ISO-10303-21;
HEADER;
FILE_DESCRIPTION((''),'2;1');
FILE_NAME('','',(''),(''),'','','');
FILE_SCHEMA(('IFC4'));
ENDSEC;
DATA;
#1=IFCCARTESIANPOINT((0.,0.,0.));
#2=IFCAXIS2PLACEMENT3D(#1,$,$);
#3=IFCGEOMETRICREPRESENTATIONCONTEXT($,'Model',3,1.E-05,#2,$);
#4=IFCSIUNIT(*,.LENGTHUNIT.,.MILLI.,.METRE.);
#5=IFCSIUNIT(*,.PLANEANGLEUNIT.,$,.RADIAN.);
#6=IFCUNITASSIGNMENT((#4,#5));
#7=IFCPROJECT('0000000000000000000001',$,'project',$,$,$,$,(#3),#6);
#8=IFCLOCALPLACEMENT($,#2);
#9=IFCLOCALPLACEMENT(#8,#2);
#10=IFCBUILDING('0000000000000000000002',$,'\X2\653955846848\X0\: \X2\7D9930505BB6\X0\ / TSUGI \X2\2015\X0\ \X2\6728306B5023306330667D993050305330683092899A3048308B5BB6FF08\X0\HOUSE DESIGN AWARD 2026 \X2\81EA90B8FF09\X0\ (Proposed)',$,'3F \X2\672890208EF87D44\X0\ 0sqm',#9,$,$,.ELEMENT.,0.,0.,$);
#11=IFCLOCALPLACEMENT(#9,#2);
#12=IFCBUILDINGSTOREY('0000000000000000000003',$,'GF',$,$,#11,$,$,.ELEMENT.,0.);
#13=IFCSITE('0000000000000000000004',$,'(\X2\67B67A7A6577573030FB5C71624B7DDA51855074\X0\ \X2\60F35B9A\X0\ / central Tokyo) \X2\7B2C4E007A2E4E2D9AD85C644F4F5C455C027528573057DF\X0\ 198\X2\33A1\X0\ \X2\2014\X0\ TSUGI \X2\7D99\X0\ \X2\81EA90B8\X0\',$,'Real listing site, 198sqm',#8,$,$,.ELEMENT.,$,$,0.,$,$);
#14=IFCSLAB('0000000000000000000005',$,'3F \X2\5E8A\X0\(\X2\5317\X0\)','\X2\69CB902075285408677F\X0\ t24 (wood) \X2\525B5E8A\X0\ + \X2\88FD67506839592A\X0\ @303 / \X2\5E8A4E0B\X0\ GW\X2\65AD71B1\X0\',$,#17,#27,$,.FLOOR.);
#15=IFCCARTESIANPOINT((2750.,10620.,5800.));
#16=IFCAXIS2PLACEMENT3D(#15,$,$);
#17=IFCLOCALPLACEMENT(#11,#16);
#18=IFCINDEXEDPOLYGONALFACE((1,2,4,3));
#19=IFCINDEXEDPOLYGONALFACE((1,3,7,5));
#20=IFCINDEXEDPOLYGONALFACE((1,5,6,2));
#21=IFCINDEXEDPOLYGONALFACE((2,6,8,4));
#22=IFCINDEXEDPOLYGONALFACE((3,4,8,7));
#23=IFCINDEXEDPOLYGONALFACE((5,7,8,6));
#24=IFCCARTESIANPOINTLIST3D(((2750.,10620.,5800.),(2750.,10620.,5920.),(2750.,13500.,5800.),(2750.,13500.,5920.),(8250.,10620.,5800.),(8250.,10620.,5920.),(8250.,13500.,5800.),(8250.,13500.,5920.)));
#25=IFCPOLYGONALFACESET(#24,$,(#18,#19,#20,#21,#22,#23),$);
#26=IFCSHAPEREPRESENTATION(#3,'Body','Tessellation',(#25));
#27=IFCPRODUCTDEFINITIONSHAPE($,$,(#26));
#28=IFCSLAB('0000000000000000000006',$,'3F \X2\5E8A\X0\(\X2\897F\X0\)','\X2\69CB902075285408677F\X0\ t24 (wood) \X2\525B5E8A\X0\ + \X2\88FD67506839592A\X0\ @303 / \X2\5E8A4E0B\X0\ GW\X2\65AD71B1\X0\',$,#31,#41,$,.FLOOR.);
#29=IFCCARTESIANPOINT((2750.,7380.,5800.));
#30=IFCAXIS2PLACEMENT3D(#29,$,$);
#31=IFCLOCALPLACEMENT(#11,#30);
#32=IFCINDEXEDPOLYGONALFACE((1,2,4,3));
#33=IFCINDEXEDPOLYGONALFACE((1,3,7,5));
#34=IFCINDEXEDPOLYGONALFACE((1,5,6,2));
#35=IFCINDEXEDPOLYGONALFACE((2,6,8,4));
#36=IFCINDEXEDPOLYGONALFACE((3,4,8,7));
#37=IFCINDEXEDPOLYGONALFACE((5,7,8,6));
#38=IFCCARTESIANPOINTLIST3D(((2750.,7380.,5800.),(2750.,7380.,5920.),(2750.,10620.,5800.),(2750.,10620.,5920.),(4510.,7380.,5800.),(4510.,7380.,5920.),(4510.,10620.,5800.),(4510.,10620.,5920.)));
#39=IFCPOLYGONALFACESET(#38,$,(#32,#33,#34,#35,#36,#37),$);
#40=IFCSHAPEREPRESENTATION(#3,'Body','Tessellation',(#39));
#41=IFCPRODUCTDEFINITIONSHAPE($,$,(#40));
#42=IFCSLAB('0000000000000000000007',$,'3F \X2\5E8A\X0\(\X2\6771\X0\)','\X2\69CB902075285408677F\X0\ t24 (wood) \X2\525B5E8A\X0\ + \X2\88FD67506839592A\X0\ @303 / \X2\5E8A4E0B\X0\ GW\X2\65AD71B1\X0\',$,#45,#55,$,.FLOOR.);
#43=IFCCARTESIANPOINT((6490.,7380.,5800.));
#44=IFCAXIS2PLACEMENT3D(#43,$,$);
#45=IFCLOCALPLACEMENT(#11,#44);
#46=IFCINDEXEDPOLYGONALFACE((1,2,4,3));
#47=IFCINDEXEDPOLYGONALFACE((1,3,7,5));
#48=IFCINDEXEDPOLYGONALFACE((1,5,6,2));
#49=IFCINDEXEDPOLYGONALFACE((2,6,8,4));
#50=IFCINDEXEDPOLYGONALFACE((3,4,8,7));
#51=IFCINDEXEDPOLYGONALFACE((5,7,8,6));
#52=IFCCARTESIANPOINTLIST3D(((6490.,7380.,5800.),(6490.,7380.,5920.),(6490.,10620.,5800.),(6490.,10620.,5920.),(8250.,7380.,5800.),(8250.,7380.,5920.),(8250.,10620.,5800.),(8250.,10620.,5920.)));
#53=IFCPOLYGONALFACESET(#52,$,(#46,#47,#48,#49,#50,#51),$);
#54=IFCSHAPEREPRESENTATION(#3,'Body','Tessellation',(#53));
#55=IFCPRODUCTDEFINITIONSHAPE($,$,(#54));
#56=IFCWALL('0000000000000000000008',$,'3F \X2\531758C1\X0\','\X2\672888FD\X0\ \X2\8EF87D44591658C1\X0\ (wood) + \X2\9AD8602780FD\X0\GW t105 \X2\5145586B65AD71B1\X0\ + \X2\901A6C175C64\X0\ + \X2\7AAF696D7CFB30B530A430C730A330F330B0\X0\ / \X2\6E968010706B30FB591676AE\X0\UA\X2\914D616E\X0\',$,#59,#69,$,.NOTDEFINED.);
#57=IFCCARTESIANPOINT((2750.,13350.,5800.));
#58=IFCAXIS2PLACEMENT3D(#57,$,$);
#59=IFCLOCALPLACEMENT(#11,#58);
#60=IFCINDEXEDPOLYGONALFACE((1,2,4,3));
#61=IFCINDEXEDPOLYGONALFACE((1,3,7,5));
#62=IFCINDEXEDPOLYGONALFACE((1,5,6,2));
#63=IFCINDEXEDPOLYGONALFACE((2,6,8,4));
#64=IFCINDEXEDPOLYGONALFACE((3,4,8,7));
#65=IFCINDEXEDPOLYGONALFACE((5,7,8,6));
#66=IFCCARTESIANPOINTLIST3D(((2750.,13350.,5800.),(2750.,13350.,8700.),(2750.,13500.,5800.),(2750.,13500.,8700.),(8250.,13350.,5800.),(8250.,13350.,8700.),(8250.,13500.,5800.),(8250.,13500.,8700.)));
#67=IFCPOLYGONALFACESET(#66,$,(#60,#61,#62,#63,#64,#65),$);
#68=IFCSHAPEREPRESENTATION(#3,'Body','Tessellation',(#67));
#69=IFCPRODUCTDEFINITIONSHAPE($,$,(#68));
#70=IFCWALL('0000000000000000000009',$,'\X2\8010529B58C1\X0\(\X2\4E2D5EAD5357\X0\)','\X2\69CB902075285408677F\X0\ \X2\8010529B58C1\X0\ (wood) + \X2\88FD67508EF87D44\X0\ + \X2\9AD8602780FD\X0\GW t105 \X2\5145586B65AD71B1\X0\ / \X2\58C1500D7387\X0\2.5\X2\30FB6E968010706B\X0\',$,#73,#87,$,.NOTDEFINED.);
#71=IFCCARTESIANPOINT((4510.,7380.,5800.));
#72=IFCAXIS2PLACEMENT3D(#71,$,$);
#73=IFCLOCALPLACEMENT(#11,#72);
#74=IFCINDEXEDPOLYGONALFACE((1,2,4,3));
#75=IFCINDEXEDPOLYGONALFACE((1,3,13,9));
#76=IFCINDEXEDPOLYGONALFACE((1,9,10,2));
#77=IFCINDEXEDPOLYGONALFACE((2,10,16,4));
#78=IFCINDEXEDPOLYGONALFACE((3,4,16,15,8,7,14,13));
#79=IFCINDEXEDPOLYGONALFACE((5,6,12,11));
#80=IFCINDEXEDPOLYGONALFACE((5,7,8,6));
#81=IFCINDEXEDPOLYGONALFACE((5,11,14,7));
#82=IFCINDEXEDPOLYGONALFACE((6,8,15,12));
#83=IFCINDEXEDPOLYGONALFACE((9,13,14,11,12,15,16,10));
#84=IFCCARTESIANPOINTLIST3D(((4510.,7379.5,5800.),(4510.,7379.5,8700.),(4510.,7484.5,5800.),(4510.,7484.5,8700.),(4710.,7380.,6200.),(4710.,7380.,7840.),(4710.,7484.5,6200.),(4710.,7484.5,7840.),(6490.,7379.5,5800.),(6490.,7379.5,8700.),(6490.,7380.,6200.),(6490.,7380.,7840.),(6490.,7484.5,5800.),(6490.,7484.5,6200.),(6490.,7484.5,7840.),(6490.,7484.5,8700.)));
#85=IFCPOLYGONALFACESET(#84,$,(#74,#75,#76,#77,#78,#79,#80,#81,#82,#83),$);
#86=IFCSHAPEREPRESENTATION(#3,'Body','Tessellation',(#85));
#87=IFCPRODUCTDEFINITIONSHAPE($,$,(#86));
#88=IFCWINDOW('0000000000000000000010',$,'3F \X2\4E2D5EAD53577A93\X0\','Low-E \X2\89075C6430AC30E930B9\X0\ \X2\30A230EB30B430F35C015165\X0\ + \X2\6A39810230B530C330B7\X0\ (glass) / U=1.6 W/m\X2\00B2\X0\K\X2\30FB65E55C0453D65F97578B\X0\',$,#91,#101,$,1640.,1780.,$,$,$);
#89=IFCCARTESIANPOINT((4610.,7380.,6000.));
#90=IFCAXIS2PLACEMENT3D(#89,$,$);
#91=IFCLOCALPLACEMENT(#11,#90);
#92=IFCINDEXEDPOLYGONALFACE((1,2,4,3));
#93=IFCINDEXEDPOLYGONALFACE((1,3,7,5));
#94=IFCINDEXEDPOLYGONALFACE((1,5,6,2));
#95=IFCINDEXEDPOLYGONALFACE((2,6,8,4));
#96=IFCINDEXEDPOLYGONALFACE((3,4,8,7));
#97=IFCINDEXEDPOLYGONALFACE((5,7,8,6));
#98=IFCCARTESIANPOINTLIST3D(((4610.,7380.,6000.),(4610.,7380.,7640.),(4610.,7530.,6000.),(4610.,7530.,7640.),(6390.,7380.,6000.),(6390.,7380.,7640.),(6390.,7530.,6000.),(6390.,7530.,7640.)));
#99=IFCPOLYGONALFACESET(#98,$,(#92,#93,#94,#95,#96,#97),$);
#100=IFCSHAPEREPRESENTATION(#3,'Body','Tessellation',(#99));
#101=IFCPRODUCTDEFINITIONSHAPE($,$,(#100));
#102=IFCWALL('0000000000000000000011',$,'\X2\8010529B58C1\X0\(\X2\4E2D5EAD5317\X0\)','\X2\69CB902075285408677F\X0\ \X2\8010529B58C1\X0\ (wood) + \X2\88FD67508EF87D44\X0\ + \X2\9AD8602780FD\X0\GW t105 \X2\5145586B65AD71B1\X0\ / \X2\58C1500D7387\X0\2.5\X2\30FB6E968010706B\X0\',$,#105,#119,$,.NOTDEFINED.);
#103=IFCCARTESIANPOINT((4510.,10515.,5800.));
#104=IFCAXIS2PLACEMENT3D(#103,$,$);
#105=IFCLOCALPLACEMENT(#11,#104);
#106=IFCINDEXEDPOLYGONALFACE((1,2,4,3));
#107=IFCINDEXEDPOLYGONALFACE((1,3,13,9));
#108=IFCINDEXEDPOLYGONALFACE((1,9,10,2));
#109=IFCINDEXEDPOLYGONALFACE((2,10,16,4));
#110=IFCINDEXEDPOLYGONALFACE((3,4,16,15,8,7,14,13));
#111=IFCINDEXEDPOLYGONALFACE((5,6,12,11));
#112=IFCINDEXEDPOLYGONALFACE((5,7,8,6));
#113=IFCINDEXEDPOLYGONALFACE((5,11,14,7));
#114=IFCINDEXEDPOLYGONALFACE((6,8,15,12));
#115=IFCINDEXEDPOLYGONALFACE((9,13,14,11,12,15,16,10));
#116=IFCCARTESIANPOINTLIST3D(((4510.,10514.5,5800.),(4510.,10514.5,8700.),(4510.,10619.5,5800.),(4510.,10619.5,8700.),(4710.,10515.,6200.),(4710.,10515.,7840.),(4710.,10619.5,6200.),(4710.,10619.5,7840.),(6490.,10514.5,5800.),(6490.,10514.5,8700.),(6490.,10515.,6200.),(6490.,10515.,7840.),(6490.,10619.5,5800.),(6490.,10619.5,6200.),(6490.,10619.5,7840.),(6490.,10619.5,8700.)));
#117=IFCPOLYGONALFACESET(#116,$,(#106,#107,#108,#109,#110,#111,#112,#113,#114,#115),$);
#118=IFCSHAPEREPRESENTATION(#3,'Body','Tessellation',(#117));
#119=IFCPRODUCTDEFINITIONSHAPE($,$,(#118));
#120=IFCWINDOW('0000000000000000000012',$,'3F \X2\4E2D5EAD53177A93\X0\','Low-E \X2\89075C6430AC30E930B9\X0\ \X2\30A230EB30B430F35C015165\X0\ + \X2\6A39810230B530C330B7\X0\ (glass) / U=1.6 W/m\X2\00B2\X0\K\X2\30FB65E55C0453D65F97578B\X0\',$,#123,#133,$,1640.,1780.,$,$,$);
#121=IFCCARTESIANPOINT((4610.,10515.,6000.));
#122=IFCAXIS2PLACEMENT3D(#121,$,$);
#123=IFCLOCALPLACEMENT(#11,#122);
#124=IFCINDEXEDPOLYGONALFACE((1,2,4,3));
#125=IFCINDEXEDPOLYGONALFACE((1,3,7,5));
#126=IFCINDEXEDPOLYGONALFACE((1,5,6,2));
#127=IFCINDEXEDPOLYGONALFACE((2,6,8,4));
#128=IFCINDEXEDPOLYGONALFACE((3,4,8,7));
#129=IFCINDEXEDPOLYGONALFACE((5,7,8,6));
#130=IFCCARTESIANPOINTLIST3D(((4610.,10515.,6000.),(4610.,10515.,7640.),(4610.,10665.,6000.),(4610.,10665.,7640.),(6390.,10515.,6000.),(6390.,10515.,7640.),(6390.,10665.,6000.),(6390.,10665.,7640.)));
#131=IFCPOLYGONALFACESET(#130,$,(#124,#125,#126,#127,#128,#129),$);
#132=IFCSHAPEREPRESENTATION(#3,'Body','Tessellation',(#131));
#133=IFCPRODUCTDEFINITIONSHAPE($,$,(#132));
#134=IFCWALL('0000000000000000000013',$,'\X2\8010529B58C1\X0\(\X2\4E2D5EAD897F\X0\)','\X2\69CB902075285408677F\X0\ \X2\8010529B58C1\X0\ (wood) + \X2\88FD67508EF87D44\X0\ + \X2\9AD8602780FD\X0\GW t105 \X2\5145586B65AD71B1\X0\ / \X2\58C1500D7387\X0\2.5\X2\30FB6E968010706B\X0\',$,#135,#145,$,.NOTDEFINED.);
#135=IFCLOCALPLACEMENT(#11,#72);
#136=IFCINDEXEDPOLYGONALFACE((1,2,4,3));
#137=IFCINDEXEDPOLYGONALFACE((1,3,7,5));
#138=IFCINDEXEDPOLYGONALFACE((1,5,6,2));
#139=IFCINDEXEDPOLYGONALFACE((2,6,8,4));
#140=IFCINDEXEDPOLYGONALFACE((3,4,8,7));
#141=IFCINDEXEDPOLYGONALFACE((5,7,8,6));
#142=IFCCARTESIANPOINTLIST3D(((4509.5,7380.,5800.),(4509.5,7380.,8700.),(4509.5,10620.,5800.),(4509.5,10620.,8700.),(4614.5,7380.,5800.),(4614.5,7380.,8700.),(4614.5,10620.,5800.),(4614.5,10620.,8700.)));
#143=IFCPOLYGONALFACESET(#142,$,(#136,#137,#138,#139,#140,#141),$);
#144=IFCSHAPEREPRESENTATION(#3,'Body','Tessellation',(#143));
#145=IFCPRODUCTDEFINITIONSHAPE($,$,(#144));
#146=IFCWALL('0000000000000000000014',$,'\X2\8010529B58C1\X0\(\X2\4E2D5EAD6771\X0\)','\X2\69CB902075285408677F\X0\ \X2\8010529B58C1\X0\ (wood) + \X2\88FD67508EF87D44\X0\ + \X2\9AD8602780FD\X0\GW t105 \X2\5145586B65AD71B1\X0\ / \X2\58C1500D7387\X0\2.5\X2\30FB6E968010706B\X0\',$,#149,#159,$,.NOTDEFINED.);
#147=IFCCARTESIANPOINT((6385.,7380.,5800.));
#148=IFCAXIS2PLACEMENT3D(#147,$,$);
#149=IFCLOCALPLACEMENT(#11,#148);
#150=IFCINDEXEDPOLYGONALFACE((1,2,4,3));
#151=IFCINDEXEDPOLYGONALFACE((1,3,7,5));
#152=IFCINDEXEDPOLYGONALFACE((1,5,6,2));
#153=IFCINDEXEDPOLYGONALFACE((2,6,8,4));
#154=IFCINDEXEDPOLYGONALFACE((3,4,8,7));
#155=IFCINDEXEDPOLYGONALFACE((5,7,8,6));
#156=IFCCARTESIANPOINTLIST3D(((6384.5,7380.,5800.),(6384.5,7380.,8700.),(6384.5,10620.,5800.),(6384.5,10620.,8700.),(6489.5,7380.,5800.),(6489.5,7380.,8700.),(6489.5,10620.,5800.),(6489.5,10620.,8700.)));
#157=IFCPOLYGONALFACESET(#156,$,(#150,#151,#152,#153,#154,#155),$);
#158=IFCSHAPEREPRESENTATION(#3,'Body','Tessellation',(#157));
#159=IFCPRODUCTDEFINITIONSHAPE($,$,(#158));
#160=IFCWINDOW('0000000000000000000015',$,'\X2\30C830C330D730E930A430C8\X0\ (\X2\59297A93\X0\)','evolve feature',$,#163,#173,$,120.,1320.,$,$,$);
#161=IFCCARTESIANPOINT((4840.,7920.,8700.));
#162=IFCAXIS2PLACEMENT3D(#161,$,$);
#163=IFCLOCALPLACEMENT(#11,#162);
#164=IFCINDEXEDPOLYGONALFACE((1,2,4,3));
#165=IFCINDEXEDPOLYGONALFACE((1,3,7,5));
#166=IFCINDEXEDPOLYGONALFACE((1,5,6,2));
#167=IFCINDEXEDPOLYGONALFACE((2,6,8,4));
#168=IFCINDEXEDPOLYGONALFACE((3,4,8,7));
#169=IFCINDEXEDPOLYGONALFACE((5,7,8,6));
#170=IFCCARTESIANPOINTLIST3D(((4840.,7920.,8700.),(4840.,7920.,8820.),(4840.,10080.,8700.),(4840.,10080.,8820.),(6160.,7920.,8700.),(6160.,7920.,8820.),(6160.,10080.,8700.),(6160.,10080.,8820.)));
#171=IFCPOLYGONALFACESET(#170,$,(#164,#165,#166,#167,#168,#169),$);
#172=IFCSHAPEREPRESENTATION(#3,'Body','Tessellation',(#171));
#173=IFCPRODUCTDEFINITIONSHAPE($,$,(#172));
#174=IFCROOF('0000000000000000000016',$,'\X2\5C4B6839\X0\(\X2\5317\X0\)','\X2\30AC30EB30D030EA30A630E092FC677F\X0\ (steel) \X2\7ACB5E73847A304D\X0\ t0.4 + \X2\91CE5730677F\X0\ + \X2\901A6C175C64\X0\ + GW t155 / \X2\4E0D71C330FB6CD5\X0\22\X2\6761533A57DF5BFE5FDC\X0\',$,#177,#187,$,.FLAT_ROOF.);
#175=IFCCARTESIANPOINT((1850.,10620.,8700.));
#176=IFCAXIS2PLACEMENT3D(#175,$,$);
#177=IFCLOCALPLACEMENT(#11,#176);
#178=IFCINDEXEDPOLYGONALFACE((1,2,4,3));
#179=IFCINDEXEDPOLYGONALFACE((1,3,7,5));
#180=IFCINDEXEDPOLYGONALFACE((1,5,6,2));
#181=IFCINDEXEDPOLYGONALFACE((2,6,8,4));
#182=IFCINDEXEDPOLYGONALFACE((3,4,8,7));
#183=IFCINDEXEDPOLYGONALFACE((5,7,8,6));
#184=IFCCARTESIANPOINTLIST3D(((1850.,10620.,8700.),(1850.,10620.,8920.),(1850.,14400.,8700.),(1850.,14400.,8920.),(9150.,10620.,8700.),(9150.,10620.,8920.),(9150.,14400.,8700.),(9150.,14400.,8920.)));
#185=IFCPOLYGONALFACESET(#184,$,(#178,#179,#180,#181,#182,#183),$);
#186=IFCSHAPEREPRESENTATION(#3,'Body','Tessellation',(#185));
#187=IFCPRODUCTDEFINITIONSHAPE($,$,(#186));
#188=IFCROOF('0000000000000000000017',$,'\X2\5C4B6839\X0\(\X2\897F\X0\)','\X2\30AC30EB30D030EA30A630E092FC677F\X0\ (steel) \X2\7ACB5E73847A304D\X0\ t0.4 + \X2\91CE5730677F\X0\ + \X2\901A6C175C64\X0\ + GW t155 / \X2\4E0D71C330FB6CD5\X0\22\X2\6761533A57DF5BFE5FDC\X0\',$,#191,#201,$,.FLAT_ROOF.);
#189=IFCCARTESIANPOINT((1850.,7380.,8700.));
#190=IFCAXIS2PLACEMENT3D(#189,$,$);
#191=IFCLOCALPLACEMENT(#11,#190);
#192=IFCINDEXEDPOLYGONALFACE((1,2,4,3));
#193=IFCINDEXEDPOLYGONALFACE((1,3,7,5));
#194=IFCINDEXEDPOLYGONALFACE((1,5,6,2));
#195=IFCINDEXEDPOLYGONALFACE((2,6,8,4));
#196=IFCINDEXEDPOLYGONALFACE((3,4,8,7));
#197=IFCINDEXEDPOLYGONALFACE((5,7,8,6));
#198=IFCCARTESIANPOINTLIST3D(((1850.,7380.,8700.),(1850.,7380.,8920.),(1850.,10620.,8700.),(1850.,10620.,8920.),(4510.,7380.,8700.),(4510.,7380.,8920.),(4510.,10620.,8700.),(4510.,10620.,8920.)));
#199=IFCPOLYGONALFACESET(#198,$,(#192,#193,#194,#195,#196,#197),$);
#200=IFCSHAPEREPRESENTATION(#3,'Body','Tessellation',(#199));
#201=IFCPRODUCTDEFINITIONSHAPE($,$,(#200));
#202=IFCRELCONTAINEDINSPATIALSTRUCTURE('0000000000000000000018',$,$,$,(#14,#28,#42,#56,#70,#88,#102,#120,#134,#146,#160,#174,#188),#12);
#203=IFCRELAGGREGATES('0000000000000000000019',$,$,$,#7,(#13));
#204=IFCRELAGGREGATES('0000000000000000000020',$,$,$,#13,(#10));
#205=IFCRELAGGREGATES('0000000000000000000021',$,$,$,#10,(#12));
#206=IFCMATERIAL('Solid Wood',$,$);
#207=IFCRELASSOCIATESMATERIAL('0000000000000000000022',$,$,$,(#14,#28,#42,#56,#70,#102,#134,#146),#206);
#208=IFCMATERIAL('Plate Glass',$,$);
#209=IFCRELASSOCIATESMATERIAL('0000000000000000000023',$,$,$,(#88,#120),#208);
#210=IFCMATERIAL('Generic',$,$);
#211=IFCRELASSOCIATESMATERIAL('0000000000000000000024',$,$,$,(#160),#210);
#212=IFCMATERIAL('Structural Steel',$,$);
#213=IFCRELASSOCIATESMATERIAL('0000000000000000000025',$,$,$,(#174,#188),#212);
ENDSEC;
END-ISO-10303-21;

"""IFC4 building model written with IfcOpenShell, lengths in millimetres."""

from ifc_helpers import new_model, si_unit, frame, frame_2d, origin, place, context, project, spatial, rectangle, extrude, material, element, fill, save


model = new_model("IFC4")

# Units and contexts
model_context = context("Model", 3, precision=1e-05, world=origin())
ifc_project = project(units=[si_unit("LENGTHUNIT", "METRE", prefix="MILLI"), si_unit("PLANEANGLEUNIT", "RADIAN")], contexts=[model_context])

# Site, building, storey
site_placement = place(None, origin())
site = spatial("IfcSite", under=ifc_project, at=site_placement, Name="(架空敷地・山手線内側 想定 / central Tokyo) 第一種中高層住居専用地域 198㎡ — TSUGI 継 自邸", ObjectType="Real listing site, 198sqm", CompositionType="ELEMENT", RefElevation=0.0)
building_placement = place(site_placement, origin())
building = spatial("IfcBuilding", under=site, at=building_placement, Name="改善案: 継ぐ家 / TSUGI ― 木に倣って継ぐことを覚える家（HOUSE DESIGN AWARD 2026 自邸） (Proposed)", ObjectType="3F 木造軸組 0sqm", CompositionType="ELEMENT", ElevationOfRefHeight=0.0, ElevationOfTerrain=0.0)
storey_placement = place(building_placement, origin())
storey = spatial("IfcBuildingStorey", under=building, at=storey_placement, Name="GF", CompositionType="ELEMENT", Elevation=0.0)

# Slabs
ifc_material_1 = material(Name="Solid Wood")
slab_1_placement = place(storey_placement, frame((2750.0, 10620.0, 5800.0)))
element("IfcSlab", 1, at=slab_1_placement, inside=storey, material=ifc_material_1, Name="3F 床(北)", Description="構造用合板 t24 (wood) 剛床 + 製材根太 @303 / 床下 GW断熱", PredefinedType="FLOOR", context=model_context, shape_type="SweptSolid", body=[
    extrude(rectangle(XDim=5500.0, YDim=2880.0, at=frame_2d((2750.0, 1440.0))), frame((2750.0, 10620.0, 5800.0)), (0.0, 0.0, 1.0), 120.0),
])
slab_2_placement = place(storey_placement, frame((2750.0, 7380.0, 5800.0)))
element("IfcSlab", 2, at=slab_2_placement, inside=storey, material=ifc_material_1, Name="3F 床(西)", Description="構造用合板 t24 (wood) 剛床 + 製材根太 @303 / 床下 GW断熱", PredefinedType="FLOOR", context=model_context, shape_type="SweptSolid", body=[
    extrude(rectangle(XDim=1760.0, YDim=3240.0, at=frame_2d((880.0, 1620.0))), frame((2750.0, 7380.0, 5800.0)), (0.0, 0.0, 1.0), 120.0),
])
slab_3_placement = place(storey_placement, frame((6490.0, 7380.0, 5800.0)))
element("IfcSlab", 3, at=slab_3_placement, inside=storey, material=ifc_material_1, Name="3F 床(東)", Description="構造用合板 t24 (wood) 剛床 + 製材根太 @303 / 床下 GW断熱", PredefinedType="FLOOR", context=model_context, shape_type="SweptSolid", body=[
    extrude(rectangle(XDim=1760.0, YDim=3240.0, at=frame_2d((880.0, 1620.0))), frame((6490.0, 7380.0, 5800.0)), (0.0, 0.0, 1.0), 120.0),
])

# Wall
wall_1_placement = place(storey_placement, frame((2750.0, 13350.0, 5800.0)))
element("IfcWall", 4, at=wall_1_placement, inside=storey, material=ifc_material_1, Name="3F 北壁", Description="木製 軸組外壁 (wood) + 高性能GW t105 充填断熱 + 通気層 + 窯業系サイディング / 準耐火・外皮UA配慮", PredefinedType="NOTDEFINED", context=model_context, shape_type="SweptSolid", body=[
    extrude(rectangle(XDim=5500.0, YDim=150.0, at=frame_2d((2750.0, 75.0))), frame((2750.0, 13350.0, 5800.0)), (0.0, 0.0, 1.0), 2900.0),
])

# Walls, openings, windows
wall_2_placement = place(storey_placement, frame((4510.0, 7380.0, 5800.0)))
wall_2 = element("IfcWall", 5, at=wall_2_placement, inside=storey, material=ifc_material_1, Name="耐力壁(中庭南)", Description="構造用合板 耐力壁 (wood) + 製材軸組 + 高性能GW t105 充填断熱 / 壁倍率2.5・準耐火", PredefinedType="NOTDEFINED", context=model_context, shape_type="SweptSolid", body=[
    extrude(rectangle(XDim=1980.0, YDim=105.0, at=frame_2d((990.0, 52.0))), frame((4510.0, 7380.0, 5800.0)), (0.0, 0.0, 1.0), 2900.0),
])
opening_1_placement = place(storey_placement, frame((4610.0, 7380.0, 6000.0)))
opening_1 = element("IfcOpeningElement", 6, at=opening_1_placement, cuts=wall_2, PredefinedType="NOTDEFINED", context=model_context, shape_type="SweptSolid", body=[
    extrude(rectangle(XDim=1780.0, YDim=150.0, at=frame_2d((890.0, 75.0))), frame((4610.0, 7380.0, 6000.0)), (0.0, 0.0, 1.0), 1640.0),
])
ifc_material_2 = material(Name="Plate Glass")
window_1_placement = place(storey_placement, frame((4610.0, 7380.0, 6000.0)))
window_1 = element("IfcWindow", 7, at=window_1_placement, inside=storey, material=ifc_material_2, Name="3F 中庭南窓", Description="Low-E 複層ガラス アルゴン封入 + 樹脂サッシ (glass) / U=1.6 W/m²K・日射取得型", OverallHeight=1640.0, OverallWidth=1780.0, context=model_context, shape_type="SweptSolid", body=[
    extrude(rectangle(XDim=1780.0, YDim=150.0, at=frame_2d((890.0, 75.0))), frame((4610.0, 7380.0, 6000.0)), (0.0, 0.0, 1.0), 1640.0),
])
fill(opening_1, window_1)
wall_3_placement = place(storey_placement, frame((4510.0, 10515.0, 5800.0)))
wall_3 = element("IfcWall", 8, at=wall_3_placement, inside=storey, material=ifc_material_1, Name="耐力壁(中庭北)", Description="構造用合板 耐力壁 (wood) + 製材軸組 + 高性能GW t105 充填断熱 / 壁倍率2.5・準耐火", PredefinedType="NOTDEFINED", context=model_context, shape_type="SweptSolid", body=[
    extrude(rectangle(XDim=1980.0, YDim=105.0, at=frame_2d((990.0, 52.0))), frame((4510.0, 10515.0, 5800.0)), (0.0, 0.0, 1.0), 2900.0),
])
opening_2_placement = place(storey_placement, frame((4610.0, 10515.0, 6000.0)))
opening_2 = element("IfcOpeningElement", 9, at=opening_2_placement, cuts=wall_3, PredefinedType="NOTDEFINED", context=model_context, shape_type="SweptSolid", body=[
    extrude(rectangle(XDim=1780.0, YDim=150.0, at=frame_2d((890.0, 75.0))), frame((4610.0, 10515.0, 6000.0)), (0.0, 0.0, 1.0), 1640.0),
])
window_2_placement = place(storey_placement, frame((4610.0, 10515.0, 6000.0)))
window_2 = element("IfcWindow", 10, at=window_2_placement, inside=storey, material=ifc_material_2, Name="3F 中庭北窓", Description="Low-E 複層ガラス アルゴン封入 + 樹脂サッシ (glass) / U=1.6 W/m²K・日射取得型", OverallHeight=1640.0, OverallWidth=1780.0, context=model_context, shape_type="SweptSolid", body=[
    extrude(rectangle(XDim=1780.0, YDim=150.0, at=frame_2d((890.0, 75.0))), frame((4610.0, 10515.0, 6000.0)), (0.0, 0.0, 1.0), 1640.0),
])
fill(opening_2, window_2)

# Walls
wall_4_placement = place(storey_placement, frame((4510.0, 7380.0, 5800.0)))
element("IfcWall", 11, at=wall_4_placement, inside=storey, material=ifc_material_1, Name="耐力壁(中庭西)", Description="構造用合板 耐力壁 (wood) + 製材軸組 + 高性能GW t105 充填断熱 / 壁倍率2.5・準耐火", PredefinedType="NOTDEFINED", context=model_context, shape_type="SweptSolid", body=[
    extrude(rectangle(XDim=105.0, YDim=3240.0, at=frame_2d((52.0, 1620.0))), frame((4510.0, 7380.0, 5800.0)), (0.0, 0.0, 1.0), 2900.0),
])
wall_5_placement = place(storey_placement, frame((6385.0, 7380.0, 5800.0)))
element("IfcWall", 12, at=wall_5_placement, inside=storey, material=ifc_material_1, Name="耐力壁(中庭東)", Description="構造用合板 耐力壁 (wood) + 製材軸組 + 高性能GW t105 充填断熱 / 壁倍率2.5・準耐火", PredefinedType="NOTDEFINED", context=model_context, shape_type="SweptSolid", body=[
    extrude(rectangle(XDim=105.0, YDim=3240.0, at=frame_2d((52.0, 1620.0))), frame((6385.0, 7380.0, 5800.0)), (0.0, 0.0, 1.0), 2900.0),
])

# Window
ifc_material_3 = material(Name="Generic")
window_3_placement = place(storey_placement, frame((4840.0, 7920.0, 8700.0)))
element("IfcWindow", 13, at=window_3_placement, inside=storey, material=ifc_material_3, Name="トップライト (天窓)", Description="evolve feature", OverallHeight=120.0, OverallWidth=1320.0, context=model_context, shape_type="SweptSolid", body=[
    extrude(rectangle(XDim=1320.0, YDim=2160.0, at=frame_2d((660.0, 1080.0))), frame((4840.0, 7920.0, 8700.0)), (0.0, 0.0, 1.0), 120.0),
])

# Roofs
ifc_material_4 = material(Name="Structural Steel")
for number, where, name in (
    (14, (1850.0, 10620.0, 8700.0), "屋根(北)"),
):
    element("IfcRoof", number, at=place(storey_placement, frame(where)), inside=storey, material=ifc_material_4, Name=name, Description="ガルバリウム鋼板 (steel) 立平葺き t0.4 + 野地板 + 通気層 + GW t155 / 不燃・法22条区域対応", PredefinedType="FLAT_ROOF", context=model_context, shape_type="SweptSolid", body=[
        extrude(rectangle(XDim=7300.0, YDim=3780.0, at=frame_2d((3650.0, 1890.0))), frame((1850.0, 10620.0, 8700.0)), (0.0, 0.0, 1.0), 220.0),
    ])
roof_1_placement = place(storey_placement, frame((1850.0, 7380.0, 8700.0)))
element("IfcRoof", 15, at=roof_1_placement, inside=storey, material=ifc_material_4, Name="屋根(西)", Description="ガルバリウム鋼板 (steel) 立平葺き t0.4 + 野地板 + 通気層 + GW t155 / 不燃・法22条区域対応", PredefinedType="FLAT_ROOF", context=model_context, shape_type="SweptSolid", body=[
    extrude(rectangle(XDim=2660.0, YDim=3240.0, at=frame_2d((1330.0, 1620.0))), frame((1850.0, 7380.0, 8700.0)), (0.0, 0.0, 1.0), 220.0),
])

save(model, "model.ifc")
